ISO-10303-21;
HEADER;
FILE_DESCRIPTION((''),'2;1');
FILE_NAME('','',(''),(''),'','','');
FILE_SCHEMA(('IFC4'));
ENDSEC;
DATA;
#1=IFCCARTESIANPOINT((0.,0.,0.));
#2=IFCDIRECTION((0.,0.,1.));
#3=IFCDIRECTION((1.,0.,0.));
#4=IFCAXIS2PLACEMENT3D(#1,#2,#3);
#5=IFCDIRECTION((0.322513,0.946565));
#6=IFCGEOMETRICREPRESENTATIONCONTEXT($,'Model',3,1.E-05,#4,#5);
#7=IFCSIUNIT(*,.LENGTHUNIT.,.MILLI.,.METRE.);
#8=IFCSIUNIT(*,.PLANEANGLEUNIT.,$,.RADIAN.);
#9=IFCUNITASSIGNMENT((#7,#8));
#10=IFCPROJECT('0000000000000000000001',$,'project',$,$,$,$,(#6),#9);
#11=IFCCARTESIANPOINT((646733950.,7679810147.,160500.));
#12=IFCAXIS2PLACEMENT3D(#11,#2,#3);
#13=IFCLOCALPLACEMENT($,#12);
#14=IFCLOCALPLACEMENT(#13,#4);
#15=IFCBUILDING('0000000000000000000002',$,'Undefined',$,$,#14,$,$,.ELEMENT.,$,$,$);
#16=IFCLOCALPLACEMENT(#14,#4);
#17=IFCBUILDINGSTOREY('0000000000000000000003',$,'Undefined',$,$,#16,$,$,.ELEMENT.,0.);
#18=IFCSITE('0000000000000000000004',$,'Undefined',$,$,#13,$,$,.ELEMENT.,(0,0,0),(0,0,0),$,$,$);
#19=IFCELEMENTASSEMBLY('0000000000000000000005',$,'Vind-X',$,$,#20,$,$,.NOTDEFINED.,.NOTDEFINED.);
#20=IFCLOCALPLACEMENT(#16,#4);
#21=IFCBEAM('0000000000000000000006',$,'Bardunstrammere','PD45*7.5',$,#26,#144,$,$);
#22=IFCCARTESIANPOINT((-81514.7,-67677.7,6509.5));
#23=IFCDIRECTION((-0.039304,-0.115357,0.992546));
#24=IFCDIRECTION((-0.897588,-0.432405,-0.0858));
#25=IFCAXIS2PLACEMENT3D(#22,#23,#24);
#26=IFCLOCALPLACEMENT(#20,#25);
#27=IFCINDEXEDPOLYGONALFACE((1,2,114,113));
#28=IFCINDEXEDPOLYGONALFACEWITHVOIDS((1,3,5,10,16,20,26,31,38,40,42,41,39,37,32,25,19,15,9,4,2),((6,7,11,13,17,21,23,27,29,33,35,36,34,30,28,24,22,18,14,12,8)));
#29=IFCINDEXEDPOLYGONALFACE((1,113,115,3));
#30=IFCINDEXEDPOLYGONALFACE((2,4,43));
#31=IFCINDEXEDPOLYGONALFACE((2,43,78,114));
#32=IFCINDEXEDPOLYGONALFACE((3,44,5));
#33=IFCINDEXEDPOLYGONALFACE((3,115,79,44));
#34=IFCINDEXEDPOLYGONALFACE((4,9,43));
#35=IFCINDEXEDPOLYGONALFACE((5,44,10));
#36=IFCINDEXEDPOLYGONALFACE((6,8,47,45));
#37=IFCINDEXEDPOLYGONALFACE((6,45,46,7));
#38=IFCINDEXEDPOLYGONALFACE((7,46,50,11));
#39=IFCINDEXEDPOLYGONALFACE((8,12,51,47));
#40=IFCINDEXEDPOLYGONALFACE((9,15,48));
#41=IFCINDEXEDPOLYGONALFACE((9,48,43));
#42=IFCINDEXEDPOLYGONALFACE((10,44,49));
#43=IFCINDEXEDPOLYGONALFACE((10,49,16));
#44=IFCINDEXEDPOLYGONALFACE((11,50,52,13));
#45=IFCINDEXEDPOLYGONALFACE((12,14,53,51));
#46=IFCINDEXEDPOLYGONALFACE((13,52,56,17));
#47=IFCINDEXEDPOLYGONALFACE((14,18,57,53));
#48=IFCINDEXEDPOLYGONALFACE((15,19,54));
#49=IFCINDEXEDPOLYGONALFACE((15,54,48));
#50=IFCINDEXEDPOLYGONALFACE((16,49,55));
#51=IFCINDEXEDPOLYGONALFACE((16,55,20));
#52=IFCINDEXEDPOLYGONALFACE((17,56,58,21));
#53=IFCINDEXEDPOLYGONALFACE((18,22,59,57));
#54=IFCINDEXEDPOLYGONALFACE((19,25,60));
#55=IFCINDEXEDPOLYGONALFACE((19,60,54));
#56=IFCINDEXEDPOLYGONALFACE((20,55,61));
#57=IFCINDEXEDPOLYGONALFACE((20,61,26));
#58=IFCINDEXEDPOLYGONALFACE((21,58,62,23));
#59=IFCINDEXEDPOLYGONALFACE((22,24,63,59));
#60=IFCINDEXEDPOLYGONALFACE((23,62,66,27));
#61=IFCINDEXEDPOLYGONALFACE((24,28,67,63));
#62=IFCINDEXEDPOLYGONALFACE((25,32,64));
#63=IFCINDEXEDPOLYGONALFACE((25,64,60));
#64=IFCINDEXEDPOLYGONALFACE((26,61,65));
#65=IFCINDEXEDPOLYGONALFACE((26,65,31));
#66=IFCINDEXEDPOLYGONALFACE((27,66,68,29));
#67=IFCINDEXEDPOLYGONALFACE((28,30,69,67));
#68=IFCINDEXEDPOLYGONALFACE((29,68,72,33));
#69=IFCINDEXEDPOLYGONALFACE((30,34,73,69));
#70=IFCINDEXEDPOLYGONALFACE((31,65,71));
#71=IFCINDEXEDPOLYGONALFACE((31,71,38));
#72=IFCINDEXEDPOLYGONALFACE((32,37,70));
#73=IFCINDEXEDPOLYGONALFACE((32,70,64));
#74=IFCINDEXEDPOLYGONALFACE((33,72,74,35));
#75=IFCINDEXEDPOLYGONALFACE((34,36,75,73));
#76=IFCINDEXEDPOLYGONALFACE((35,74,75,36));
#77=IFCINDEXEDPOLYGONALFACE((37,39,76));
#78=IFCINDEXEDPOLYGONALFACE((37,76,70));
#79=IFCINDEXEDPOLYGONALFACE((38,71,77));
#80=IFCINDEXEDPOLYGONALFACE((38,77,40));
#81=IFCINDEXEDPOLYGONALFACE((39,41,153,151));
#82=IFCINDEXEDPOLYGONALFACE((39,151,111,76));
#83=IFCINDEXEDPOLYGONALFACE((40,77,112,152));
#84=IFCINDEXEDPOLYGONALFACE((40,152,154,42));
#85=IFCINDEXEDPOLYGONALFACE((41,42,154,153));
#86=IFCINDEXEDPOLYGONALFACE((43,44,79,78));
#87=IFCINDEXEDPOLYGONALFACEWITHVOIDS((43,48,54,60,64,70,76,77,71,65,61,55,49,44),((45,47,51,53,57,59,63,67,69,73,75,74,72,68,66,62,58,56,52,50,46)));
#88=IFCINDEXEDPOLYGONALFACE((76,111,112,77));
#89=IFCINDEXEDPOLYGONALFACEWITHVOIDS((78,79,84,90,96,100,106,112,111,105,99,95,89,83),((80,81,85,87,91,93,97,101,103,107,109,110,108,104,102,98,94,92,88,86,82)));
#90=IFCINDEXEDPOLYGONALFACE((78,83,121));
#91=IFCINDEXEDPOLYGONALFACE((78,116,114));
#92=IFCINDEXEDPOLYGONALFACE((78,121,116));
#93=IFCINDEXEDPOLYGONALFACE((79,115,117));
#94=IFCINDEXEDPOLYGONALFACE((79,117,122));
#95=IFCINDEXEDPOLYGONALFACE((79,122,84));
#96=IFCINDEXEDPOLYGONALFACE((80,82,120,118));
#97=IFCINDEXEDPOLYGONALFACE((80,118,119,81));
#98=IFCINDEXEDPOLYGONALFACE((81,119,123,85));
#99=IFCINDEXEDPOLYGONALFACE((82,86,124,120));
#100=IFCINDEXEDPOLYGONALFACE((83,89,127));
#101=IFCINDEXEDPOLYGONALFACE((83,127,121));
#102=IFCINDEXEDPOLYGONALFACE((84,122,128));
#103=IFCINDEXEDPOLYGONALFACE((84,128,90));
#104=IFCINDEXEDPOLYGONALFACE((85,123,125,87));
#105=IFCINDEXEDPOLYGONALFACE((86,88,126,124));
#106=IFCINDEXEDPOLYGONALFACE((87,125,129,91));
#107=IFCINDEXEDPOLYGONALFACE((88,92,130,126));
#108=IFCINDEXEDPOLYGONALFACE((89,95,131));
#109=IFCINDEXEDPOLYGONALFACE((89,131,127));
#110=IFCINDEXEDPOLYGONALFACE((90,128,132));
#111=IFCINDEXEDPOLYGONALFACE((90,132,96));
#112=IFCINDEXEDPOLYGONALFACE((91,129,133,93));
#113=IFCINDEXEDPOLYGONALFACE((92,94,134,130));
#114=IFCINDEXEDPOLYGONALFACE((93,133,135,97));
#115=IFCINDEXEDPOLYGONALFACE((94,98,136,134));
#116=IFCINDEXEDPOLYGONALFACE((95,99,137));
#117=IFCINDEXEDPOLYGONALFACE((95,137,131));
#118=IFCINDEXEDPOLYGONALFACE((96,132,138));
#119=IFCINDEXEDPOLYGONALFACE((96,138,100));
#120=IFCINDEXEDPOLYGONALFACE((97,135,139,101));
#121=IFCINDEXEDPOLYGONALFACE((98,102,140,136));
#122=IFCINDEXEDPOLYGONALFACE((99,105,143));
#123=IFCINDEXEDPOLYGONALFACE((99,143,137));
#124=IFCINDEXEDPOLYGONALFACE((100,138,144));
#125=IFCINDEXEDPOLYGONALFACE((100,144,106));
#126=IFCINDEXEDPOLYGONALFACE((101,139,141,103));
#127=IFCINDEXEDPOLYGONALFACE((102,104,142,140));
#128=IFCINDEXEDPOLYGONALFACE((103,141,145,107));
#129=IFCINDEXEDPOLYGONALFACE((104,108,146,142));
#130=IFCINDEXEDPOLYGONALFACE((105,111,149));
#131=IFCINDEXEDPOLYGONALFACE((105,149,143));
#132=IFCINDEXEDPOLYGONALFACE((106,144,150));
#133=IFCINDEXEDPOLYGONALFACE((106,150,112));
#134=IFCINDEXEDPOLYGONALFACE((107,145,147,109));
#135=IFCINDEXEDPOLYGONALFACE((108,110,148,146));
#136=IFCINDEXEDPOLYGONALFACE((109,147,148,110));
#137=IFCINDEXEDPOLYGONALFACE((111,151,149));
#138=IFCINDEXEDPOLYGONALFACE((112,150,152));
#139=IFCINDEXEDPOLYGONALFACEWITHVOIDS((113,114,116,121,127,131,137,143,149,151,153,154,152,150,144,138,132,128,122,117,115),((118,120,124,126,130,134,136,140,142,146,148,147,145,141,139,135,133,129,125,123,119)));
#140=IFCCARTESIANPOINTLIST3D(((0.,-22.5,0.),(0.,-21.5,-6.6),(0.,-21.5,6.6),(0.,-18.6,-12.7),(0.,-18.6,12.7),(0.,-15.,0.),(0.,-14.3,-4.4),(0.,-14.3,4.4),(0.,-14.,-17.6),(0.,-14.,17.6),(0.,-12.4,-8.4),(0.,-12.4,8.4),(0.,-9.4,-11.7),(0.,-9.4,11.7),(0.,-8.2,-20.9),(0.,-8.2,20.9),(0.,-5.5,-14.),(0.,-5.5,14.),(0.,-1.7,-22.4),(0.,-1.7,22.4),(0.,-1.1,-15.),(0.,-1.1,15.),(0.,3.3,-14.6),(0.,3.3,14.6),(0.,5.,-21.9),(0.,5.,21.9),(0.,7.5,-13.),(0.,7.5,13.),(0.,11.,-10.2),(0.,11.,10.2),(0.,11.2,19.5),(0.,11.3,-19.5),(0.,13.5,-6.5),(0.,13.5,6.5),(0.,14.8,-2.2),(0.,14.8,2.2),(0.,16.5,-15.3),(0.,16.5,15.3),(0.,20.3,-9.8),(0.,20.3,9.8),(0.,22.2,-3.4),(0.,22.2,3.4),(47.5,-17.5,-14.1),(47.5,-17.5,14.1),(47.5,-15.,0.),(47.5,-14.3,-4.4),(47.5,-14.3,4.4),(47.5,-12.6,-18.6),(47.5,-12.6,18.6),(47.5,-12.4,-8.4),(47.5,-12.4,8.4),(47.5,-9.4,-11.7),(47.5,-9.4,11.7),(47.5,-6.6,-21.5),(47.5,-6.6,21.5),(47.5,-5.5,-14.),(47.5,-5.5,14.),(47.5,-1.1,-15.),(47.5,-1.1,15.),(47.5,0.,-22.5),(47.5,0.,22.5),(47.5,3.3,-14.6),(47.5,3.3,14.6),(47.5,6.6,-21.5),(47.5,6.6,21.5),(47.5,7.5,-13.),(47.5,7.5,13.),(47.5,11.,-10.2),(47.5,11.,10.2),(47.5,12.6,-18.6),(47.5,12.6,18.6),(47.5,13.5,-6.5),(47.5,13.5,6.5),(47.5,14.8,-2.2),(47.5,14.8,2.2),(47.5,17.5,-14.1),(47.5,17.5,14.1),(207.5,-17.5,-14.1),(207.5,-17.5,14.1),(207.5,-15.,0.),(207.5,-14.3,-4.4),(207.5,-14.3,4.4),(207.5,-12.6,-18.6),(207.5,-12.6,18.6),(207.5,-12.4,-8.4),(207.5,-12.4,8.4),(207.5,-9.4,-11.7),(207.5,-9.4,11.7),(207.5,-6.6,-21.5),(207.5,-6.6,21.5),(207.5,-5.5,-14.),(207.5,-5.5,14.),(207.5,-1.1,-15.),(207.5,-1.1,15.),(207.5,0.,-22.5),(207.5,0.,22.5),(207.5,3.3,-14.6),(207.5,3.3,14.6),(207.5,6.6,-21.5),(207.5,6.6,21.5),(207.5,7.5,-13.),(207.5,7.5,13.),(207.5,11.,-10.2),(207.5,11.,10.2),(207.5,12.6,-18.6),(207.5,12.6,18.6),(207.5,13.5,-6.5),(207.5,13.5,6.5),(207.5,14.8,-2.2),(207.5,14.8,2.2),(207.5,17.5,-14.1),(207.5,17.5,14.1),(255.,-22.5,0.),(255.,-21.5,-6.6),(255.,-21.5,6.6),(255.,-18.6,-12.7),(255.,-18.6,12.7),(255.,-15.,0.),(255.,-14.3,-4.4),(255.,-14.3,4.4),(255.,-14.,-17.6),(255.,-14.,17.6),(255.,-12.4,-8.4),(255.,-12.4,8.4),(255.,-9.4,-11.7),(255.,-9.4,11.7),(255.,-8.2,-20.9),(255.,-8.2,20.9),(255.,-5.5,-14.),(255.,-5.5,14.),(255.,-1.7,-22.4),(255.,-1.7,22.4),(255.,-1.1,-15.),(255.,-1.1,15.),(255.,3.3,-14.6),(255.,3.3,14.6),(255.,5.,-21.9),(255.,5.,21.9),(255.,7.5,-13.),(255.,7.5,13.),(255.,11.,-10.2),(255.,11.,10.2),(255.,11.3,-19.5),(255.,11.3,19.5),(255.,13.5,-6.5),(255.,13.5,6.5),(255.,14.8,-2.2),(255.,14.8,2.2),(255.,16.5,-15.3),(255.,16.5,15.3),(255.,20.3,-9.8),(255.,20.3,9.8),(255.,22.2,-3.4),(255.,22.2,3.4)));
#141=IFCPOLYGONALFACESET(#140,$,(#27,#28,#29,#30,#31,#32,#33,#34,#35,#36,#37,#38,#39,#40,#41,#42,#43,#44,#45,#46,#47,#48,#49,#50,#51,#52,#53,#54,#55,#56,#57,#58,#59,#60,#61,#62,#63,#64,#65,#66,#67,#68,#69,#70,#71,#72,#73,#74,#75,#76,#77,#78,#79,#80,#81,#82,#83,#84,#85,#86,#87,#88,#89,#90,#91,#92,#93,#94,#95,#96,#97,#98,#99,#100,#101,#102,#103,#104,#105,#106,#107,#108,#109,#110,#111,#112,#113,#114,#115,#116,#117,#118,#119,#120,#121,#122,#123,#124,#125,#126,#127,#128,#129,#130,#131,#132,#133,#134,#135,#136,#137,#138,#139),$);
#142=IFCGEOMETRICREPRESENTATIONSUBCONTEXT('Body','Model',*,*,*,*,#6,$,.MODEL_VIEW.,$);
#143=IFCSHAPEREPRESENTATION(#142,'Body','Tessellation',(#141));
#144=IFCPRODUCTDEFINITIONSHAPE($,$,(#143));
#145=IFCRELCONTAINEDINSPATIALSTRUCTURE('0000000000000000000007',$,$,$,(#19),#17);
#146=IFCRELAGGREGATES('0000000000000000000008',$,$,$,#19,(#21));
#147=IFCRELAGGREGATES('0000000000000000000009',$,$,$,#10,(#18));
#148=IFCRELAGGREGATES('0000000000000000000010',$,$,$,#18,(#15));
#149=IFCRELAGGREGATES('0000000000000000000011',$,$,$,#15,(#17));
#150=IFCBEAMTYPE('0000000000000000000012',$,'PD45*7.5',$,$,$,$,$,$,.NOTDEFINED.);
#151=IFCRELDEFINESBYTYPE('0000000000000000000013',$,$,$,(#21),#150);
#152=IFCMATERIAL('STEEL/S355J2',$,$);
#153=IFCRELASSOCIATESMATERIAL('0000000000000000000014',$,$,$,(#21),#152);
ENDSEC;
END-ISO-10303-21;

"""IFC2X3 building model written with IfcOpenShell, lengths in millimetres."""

from ifc_helpers import new_model, si_unit, direction, frame, origin_with_axes, origin_2d_with_axis, place, context, subcontext, project, spatial, rectangle, hollow_circle, extrude, boolean, material, type_object, element, aggregate, save


model = new_model("IFC2X3")

# Units and contexts
model_context = context("Model", 3, precision=1e-05, world=origin_with_axes(), true_north=direction((0.322513, 0.946565)))
body_context = subcontext(model_context, "Body", "Model", "MODEL_VIEW")
ifc_project = project(units=[si_unit("LENGTHUNIT", "METRE", prefix="MILLI"), si_unit("PLANEANGLEUNIT", "RADIAN")], contexts=[model_context])

# Site, building, storey
site_placement = place(None, frame((646733950.0, 7679810147.0, 160500.0), z_axis=(0.0, 0.0, 1.0), x_axis=(1.0, 0.0, 0.0)))
site = spatial("IfcSite", under=ifc_project, at=site_placement, Name="Undefined", CompositionType="ELEMENT", RefLatitude=(0, 0, 0), RefLongitude=(0, 0, 0))
building_placement = place(site_placement, origin_with_axes())
building = spatial("IfcBuilding", under=site, at=building_placement, Name="Undefined", CompositionType="ELEMENT")
storey_placement = place(building_placement, origin_with_axes())
storey = spatial("IfcBuildingStorey", under=building, at=storey_placement, Name="Undefined", CompositionType="ELEMENT", Elevation=0.0)

# Element assembly, beam
assembly_1_placement = place(storey_placement, origin_with_axes())
assembly_1 = element("IfcElementAssembly", 1, at=assembly_1_placement, inside=storey, Name="Vind-X", AssemblyPlace="NOTDEFINED", PredefinedType="NOTDEFINED")
ifc_material_1 = material(Name="STEEL/S355J2")
beam_type_1 = type_object("IfcBeamType", Name="PD45*7.5", PredefinedType="NOTDEFINED")
beam_1_placement = place(assembly_1_placement, frame((-81514.7, -67677.7, 6509.5), z_axis=(-0.039304, -0.115357, 0.992546), x_axis=(-0.897588, -0.432405, -0.0858)))
beam_1 = element("IfcBeam", 2, at=beam_1_placement, type_object=beam_type_1, material=ifc_material_1, Name="Bardunstrammere", Description="PD45*7.5", context=body_context, shape_type="CSG", body=[
    boolean("DIFFERENCE", extrude(hollow_circle(Radius=22.5, WallThickness=7.5, at=origin_2d_with_axis()), frame((255.0, 0.0, 0.0), z_axis=(-1.0, 0.0, 0.0), x_axis=(0.0, -1.0, 0.0)), (0.0, 0.0, 1.0), 255.0), extrude(rectangle(XDim=35.0, YDim=90.0, at=origin_2d_with_axis()), frame((207.5, 0.0, 0.0), z_axis=(-1.0, 0.0, 0.0), x_axis=(0.0, -1.0, 0.0)), (0.0, 0.0, 1.0), 160.0)),
])

aggregate(assembly_1, [beam_1])

save(model, "model.ifc")
